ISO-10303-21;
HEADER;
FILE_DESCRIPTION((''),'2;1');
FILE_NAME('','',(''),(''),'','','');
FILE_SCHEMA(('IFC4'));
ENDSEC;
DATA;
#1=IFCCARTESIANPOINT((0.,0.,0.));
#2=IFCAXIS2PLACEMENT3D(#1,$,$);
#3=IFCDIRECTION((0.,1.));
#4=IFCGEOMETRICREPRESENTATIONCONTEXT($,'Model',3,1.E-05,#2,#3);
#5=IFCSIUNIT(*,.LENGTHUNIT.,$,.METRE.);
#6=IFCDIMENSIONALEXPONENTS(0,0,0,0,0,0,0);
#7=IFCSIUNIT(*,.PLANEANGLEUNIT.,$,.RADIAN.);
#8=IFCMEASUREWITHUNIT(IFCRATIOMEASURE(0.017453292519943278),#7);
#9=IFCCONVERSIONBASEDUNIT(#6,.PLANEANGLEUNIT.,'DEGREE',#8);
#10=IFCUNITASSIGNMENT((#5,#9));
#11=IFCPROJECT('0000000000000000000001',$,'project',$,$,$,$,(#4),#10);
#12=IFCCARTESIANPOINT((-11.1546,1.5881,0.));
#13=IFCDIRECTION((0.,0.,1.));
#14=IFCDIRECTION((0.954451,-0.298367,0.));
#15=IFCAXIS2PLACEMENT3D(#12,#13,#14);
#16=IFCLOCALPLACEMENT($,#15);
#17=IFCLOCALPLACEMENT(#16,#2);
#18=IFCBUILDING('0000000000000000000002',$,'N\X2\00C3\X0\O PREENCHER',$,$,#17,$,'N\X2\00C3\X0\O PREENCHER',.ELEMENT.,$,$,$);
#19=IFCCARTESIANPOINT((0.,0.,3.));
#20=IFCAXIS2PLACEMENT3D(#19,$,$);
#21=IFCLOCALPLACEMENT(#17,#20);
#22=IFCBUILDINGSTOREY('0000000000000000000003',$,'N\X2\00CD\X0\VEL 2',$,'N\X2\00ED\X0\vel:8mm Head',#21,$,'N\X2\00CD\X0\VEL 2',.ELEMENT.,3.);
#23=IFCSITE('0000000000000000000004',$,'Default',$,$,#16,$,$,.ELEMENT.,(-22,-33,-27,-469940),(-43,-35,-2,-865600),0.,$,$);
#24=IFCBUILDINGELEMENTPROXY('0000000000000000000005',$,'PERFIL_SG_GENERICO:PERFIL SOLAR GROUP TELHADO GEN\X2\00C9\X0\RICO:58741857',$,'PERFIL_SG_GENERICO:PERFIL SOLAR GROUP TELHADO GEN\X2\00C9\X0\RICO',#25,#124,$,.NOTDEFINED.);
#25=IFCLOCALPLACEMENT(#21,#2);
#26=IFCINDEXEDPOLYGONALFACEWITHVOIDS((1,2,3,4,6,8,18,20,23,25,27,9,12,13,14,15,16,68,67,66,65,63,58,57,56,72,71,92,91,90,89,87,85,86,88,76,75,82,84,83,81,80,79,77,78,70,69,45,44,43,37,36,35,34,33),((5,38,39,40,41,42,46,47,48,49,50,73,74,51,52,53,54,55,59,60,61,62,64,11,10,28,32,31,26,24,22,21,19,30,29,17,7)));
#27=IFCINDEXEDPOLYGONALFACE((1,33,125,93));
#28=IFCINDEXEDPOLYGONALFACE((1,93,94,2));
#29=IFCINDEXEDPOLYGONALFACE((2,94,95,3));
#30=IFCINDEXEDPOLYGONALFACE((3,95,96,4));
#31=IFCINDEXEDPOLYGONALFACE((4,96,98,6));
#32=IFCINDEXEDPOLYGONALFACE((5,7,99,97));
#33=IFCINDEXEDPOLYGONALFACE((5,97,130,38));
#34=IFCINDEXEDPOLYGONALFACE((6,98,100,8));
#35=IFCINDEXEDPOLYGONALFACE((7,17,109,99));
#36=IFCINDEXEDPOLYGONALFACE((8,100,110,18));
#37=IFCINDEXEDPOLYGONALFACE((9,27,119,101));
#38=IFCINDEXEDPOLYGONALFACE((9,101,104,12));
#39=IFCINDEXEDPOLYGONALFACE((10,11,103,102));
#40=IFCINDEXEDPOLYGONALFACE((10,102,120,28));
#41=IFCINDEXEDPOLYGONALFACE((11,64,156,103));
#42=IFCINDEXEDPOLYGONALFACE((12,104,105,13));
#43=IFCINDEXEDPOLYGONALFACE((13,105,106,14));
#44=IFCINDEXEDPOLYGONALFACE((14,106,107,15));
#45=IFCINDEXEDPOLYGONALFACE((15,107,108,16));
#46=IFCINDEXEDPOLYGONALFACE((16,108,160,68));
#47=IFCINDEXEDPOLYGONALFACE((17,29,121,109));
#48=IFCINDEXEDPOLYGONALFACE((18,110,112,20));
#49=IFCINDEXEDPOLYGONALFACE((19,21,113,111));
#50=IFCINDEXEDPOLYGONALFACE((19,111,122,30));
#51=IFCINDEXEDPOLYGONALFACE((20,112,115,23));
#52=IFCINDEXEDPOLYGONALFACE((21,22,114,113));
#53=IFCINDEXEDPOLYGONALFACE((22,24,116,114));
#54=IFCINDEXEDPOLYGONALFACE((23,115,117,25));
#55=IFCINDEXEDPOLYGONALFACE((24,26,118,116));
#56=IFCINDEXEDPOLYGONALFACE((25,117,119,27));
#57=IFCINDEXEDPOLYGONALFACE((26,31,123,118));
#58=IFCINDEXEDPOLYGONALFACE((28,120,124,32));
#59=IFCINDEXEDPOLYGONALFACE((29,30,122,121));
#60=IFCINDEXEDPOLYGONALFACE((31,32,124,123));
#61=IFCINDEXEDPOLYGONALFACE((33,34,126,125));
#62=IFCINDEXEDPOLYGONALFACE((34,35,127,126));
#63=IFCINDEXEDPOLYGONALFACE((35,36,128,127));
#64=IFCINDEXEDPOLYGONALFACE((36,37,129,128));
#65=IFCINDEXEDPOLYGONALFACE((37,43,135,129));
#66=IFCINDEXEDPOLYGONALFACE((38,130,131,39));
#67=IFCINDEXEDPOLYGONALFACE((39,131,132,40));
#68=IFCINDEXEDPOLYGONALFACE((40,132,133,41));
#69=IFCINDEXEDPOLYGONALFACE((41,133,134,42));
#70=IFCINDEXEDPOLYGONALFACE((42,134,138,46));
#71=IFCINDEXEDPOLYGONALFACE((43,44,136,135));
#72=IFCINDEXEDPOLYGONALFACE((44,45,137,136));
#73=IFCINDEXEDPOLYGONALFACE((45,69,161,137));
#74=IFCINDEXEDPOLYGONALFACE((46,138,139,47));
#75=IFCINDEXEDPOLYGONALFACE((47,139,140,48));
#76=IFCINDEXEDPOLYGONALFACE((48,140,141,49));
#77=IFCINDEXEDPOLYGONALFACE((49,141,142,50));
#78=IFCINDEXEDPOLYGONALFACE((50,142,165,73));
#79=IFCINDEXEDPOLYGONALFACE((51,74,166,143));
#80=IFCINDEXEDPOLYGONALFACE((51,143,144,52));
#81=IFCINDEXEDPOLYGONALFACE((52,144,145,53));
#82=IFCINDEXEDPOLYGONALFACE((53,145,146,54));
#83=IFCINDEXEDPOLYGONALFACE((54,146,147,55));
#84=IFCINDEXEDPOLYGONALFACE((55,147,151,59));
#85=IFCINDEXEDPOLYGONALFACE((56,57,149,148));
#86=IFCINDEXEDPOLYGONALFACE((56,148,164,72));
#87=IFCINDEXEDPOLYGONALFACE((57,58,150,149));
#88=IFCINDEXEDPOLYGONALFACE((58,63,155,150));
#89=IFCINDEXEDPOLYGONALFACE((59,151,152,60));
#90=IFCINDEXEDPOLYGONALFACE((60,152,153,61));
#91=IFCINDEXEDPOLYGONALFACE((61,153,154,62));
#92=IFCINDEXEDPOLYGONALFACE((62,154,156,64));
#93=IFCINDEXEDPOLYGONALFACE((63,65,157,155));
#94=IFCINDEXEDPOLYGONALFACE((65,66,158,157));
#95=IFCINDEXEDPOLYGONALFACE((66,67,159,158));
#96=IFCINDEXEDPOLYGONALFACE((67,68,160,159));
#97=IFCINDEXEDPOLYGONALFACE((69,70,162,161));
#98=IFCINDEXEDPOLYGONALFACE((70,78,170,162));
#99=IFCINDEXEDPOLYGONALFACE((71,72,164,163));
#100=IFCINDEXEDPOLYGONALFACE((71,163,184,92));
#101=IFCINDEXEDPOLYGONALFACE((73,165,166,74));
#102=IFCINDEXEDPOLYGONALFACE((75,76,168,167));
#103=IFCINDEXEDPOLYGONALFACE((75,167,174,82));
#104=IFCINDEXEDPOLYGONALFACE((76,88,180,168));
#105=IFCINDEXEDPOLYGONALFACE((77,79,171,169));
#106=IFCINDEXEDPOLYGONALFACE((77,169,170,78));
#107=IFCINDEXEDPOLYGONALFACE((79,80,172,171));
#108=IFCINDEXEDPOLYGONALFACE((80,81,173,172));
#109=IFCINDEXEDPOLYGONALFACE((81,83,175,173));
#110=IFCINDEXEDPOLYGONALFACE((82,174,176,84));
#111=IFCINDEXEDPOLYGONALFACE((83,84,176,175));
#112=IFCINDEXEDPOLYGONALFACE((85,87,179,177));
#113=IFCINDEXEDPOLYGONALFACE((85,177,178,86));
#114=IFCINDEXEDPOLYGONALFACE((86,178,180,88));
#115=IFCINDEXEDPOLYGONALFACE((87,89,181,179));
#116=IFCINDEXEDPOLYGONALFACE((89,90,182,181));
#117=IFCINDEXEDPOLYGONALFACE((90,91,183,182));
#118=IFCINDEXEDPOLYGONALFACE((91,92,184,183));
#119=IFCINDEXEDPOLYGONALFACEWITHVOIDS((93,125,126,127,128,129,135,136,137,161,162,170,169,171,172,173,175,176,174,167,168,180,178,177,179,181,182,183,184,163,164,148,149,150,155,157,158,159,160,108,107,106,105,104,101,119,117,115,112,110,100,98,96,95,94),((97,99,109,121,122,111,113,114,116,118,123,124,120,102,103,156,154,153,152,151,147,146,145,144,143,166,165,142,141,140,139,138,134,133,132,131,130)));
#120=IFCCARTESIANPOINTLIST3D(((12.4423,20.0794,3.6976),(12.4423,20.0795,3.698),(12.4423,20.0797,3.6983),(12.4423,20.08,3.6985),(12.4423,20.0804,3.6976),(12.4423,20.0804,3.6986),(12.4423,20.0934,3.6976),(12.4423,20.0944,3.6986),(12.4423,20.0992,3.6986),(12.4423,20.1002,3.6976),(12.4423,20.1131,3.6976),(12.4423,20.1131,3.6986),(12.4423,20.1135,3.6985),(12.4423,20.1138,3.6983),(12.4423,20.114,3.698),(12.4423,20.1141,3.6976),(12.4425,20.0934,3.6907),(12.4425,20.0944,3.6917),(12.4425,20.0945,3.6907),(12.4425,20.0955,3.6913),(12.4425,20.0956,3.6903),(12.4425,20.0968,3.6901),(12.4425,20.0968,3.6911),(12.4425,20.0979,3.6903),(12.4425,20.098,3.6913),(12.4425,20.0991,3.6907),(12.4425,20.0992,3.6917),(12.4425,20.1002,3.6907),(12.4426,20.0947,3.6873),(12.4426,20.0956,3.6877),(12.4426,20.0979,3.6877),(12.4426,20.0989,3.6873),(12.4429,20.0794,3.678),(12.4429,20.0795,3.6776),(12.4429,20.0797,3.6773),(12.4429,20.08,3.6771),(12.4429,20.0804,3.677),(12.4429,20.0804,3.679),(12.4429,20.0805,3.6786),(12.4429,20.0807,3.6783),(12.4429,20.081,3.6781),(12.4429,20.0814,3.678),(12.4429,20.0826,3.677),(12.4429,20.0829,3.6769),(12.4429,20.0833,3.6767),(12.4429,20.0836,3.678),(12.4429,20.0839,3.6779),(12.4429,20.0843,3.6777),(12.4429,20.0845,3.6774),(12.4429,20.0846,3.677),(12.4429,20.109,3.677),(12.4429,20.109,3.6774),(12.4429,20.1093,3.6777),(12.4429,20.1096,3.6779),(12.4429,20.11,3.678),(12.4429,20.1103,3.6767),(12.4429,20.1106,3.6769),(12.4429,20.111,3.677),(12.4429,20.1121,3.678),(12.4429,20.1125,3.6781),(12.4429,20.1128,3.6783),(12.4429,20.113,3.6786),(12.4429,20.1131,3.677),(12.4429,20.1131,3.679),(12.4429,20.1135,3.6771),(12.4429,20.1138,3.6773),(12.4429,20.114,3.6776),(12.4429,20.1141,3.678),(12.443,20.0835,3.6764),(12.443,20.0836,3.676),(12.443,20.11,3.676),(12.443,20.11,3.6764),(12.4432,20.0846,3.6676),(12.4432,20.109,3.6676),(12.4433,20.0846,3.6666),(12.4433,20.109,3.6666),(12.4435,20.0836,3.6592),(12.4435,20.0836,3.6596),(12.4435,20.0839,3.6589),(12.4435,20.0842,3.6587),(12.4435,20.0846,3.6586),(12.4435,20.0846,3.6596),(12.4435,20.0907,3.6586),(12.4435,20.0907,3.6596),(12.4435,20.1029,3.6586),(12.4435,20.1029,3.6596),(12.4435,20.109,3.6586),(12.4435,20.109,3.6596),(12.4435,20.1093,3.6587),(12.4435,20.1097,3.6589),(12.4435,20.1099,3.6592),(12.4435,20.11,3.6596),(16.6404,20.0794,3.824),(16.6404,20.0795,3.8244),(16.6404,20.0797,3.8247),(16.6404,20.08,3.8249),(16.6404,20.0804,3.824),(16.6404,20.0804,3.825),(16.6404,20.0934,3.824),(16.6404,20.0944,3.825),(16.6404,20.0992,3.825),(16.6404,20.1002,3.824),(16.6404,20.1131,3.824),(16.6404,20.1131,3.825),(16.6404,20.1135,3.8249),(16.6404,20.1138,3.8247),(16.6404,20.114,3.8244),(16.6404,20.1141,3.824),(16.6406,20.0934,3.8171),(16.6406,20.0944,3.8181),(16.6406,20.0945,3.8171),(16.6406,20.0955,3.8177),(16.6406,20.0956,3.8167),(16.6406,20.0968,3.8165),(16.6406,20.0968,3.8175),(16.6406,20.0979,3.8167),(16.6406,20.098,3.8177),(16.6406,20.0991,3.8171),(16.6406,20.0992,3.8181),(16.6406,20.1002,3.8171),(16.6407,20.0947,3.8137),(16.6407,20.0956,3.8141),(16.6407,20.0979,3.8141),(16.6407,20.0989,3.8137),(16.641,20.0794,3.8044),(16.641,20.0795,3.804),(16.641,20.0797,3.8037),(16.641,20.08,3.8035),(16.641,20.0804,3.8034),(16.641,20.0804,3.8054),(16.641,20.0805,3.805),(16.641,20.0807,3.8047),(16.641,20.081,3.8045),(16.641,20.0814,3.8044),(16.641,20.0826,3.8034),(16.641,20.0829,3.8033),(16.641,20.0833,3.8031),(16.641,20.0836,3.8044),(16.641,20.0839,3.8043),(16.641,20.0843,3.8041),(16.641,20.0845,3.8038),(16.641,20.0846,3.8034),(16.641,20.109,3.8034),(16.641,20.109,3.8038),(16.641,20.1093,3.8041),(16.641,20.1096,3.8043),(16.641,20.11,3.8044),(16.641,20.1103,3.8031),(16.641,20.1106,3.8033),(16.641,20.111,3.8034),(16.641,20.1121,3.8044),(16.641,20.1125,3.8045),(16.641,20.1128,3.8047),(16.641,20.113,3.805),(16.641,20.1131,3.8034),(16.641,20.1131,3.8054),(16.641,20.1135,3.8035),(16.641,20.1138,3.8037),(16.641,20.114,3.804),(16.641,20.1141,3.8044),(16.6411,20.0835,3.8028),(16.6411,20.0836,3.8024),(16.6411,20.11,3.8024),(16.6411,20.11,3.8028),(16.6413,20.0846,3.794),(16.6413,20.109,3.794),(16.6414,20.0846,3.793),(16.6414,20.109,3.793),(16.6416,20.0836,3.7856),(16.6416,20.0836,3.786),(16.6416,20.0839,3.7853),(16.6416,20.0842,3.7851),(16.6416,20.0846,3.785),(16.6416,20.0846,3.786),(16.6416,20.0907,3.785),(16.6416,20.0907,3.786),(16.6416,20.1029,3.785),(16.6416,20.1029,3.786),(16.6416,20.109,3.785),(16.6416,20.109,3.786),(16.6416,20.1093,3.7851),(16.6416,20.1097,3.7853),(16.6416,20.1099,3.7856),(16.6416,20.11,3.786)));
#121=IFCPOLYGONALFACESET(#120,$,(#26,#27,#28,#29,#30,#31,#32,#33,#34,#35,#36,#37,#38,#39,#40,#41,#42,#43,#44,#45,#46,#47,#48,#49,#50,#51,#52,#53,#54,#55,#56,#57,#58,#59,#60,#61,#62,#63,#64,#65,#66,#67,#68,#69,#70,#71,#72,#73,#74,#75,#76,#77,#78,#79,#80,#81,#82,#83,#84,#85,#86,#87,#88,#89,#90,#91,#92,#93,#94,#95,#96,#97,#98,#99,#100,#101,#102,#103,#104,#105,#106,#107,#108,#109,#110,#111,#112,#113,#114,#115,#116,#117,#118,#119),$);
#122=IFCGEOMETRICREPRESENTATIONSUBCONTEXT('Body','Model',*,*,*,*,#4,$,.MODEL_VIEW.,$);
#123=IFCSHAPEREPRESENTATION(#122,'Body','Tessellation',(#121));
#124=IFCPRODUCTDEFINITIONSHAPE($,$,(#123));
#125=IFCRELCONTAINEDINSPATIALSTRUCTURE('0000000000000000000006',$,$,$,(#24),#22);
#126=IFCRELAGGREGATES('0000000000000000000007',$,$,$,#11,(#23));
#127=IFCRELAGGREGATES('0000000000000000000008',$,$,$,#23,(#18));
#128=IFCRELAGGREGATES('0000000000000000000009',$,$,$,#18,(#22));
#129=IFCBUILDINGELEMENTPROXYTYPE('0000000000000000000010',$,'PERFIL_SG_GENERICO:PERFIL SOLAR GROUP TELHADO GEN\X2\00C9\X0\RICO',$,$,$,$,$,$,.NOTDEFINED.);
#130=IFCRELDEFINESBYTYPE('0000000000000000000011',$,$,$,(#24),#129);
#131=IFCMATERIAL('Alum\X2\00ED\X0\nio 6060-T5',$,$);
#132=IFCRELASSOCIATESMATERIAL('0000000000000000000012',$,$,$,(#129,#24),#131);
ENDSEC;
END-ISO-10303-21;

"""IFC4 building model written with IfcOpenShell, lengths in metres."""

from ifc_helpers import new_model, entity, si_unit, converted_unit, direction, frame, origin, place, context, subcontext, project, spatial, line, arc, indexed_curve, outline, extrude, source, transform, mapped, material, type_object, type_shapes, element, save


model = new_model("IFC4")

# Units and contexts
model_context = context("Model", 3, precision=1e-05, world=origin(), true_north=direction((0.0, 1.0)))
body_context = subcontext(model_context, "Body", "Model", "MODEL_VIEW")
ifc_project = project(units=[si_unit("LENGTHUNIT", "METRE"), converted_unit("PLANEANGLEUNIT", "DEGREE", entity("IfcRatioMeasure", 0.017453292519943278), si_unit("PLANEANGLEUNIT", "RADIAN"), dimensions=[0, 0, 0, 0, 0, 0, 0])], contexts=[model_context])

# Site, building, storey
site_placement = place(None, frame((-11.1546, 1.5881, 0.0), z_axis=(0.0, 0.0, 1.0), x_axis=(0.954451, -0.298367, 0.0)))
site = spatial("IfcSite", under=ifc_project, at=site_placement, Name="Default", CompositionType="ELEMENT", RefLatitude=(-22, -33, -27, -469940), RefLongitude=(-43, -35, -2, -865600), RefElevation=0.0)
building_placement = place(site_placement, origin())
building = spatial("IfcBuilding", under=site, at=building_placement, Name="NÃO PREENCHER", LongName="NÃO PREENCHER", CompositionType="ELEMENT")
storey_placement = place(building_placement, frame((0.0, 0.0, 3.0)))
storey = spatial("IfcBuildingStorey", under=building, at=storey_placement, Name="NÍVEL 2", ObjectType="Nível:8mm Head", LongName="NÍVEL 2", CompositionType="ELEMENT", Elevation=3.0)

# Building element proxy
ifc_material_1 = material(Name="Alumínio 6060-T5")
building_element_proxy_type_1 = type_object("IfcBuildingElementProxyType", Name="PERFIL_SG_GENERICO:PERFIL SOLAR GROUP TELHADO GENÉRICO", PredefinedType="NOTDEFINED", material=ifc_material_1)
shared_shape_1 = source(origin(), body_context, "Body", "SweptSolid", [
    extrude(outline(indexed_curve([(-0.0122, -0.0169), (-0.0061, -0.0169), (-0.0061, -0.0159), (-0.0122, -0.0159), (-0.0122, -0.0089), (0.0122, -0.0089), (0.0122, -0.0159), (0.0061, -0.0159), (0.0061, -0.0169), (0.0122, -0.0169), (0.0129, -0.0166), (0.0132, -0.0159), (0.0132, 0.0005), (0.0135, 0.0012), (0.0142, 0.0015), (0.0164, 0.0015), (0.0171, 0.0018), (0.0174, 0.0025), (0.0174, 0.0221), (0.0171, 0.0228), (0.0164, 0.0231), (0.0024, 0.0231), (0.0024, 0.0162), (0.0, 0.0156), (-0.0024, 0.0162), (-0.0024, 0.0231), (-0.0164, 0.0231), (-0.0171, 0.0228), (-0.0174, 0.0221), (-0.0174, 0.0025), (-0.0171, 0.0018), (-0.0164, 0.0015), (-0.0142, 0.0015), (-0.0135, 0.0012), (-0.0132, 0.0005), (-0.0132, -0.0159), (-0.0129, -0.0166)], segments=[line(1, 2, 3, 4, 5, 6, 7, 8, 9, 10), arc(10, 11, 12), line(12, 13), arc(13, 14, 15), line(15, 16), arc(16, 17, 18), line(18, 19), arc(19, 20, 21), line(21, 22, 23), arc(23, 24, 25), line(25, 26, 27), arc(27, 28, 29), line(29, 30), arc(30, 31, 32), line(32, 33), arc(33, 34, 35), line(35, 36), arc(36, 37, 1)], self_intersect=False), holes=[indexed_curve([(-0.0122, -0.0079), (-0.0122, 0.0015), (-0.0125, 0.0022), (-0.0132, 0.0025), (-0.0154, 0.0025), (-0.0161, 0.0028), (-0.0164, 0.0035), (-0.0164, 0.0221), (-0.0034, 0.0221), (-0.0034, 0.0152), (-0.0021, 0.0118), (-0.0012, 0.0122), (-0.0023, 0.0151), (0.0, 0.0146), (0.0023, 0.0151), (0.0012, 0.0122), (0.0021, 0.0118), (0.0034, 0.0152), (0.0034, 0.0221), (0.0164, 0.0221), (0.0164, 0.0035), (0.0161, 0.0028), (0.0154, 0.0025), (0.0132, 0.0025), (0.0125, 0.0022), (0.0122, 0.0015), (0.0122, -0.0079)], segments=[line(1, 2), arc(2, 3, 4), line(4, 5), arc(5, 6, 7), line(7, 8, 9, 10, 11, 12, 13), arc(13, 14, 15), line(15, 16, 17, 18, 19, 20, 21), arc(21, 22, 23), line(23, 24), arc(24, 25, 26), line(26, 27, 1)], self_intersect=False)]), frame((0.0, 0.0, 0.0169), z_axis=(1.0, 0.0, 0.0), x_axis=(0.0, 1.0, 0.0)), (0.0, 0.0, 1.0), 4.2),
])
type_shapes(building_element_proxy_type_1, [shared_shape_1])
for number, where, z_axis, x_axis, name in (
    (1, (12.4435, 20.0968, 3.6586), (-0.030095, 0.0, 0.999547), (0.999547, 0.0, 0.030095), "PERFIL_SG_GENERICO:PERFIL SOLAR GROUP TELHADO GENÉRICO:58741857"),
):
    element("IfcBuildingElementProxy", number, at=place(storey_placement, frame(where, z_axis=z_axis, x_axis=x_axis)), inside=storey, type_object=building_element_proxy_type_1, material=ifc_material_1, Name=name, ObjectType="PERFIL_SG_GENERICO:PERFIL SOLAR GROUP TELHADO GENÉRICO", PredefinedType="NOTDEFINED", context=body_context, shape_type="MappedRepresentation", body=[
        mapped(shared_shape_1, transform((0.0, 0.0, 0.0), scale=1.0)),
    ])

save(model, "model.ifc")
